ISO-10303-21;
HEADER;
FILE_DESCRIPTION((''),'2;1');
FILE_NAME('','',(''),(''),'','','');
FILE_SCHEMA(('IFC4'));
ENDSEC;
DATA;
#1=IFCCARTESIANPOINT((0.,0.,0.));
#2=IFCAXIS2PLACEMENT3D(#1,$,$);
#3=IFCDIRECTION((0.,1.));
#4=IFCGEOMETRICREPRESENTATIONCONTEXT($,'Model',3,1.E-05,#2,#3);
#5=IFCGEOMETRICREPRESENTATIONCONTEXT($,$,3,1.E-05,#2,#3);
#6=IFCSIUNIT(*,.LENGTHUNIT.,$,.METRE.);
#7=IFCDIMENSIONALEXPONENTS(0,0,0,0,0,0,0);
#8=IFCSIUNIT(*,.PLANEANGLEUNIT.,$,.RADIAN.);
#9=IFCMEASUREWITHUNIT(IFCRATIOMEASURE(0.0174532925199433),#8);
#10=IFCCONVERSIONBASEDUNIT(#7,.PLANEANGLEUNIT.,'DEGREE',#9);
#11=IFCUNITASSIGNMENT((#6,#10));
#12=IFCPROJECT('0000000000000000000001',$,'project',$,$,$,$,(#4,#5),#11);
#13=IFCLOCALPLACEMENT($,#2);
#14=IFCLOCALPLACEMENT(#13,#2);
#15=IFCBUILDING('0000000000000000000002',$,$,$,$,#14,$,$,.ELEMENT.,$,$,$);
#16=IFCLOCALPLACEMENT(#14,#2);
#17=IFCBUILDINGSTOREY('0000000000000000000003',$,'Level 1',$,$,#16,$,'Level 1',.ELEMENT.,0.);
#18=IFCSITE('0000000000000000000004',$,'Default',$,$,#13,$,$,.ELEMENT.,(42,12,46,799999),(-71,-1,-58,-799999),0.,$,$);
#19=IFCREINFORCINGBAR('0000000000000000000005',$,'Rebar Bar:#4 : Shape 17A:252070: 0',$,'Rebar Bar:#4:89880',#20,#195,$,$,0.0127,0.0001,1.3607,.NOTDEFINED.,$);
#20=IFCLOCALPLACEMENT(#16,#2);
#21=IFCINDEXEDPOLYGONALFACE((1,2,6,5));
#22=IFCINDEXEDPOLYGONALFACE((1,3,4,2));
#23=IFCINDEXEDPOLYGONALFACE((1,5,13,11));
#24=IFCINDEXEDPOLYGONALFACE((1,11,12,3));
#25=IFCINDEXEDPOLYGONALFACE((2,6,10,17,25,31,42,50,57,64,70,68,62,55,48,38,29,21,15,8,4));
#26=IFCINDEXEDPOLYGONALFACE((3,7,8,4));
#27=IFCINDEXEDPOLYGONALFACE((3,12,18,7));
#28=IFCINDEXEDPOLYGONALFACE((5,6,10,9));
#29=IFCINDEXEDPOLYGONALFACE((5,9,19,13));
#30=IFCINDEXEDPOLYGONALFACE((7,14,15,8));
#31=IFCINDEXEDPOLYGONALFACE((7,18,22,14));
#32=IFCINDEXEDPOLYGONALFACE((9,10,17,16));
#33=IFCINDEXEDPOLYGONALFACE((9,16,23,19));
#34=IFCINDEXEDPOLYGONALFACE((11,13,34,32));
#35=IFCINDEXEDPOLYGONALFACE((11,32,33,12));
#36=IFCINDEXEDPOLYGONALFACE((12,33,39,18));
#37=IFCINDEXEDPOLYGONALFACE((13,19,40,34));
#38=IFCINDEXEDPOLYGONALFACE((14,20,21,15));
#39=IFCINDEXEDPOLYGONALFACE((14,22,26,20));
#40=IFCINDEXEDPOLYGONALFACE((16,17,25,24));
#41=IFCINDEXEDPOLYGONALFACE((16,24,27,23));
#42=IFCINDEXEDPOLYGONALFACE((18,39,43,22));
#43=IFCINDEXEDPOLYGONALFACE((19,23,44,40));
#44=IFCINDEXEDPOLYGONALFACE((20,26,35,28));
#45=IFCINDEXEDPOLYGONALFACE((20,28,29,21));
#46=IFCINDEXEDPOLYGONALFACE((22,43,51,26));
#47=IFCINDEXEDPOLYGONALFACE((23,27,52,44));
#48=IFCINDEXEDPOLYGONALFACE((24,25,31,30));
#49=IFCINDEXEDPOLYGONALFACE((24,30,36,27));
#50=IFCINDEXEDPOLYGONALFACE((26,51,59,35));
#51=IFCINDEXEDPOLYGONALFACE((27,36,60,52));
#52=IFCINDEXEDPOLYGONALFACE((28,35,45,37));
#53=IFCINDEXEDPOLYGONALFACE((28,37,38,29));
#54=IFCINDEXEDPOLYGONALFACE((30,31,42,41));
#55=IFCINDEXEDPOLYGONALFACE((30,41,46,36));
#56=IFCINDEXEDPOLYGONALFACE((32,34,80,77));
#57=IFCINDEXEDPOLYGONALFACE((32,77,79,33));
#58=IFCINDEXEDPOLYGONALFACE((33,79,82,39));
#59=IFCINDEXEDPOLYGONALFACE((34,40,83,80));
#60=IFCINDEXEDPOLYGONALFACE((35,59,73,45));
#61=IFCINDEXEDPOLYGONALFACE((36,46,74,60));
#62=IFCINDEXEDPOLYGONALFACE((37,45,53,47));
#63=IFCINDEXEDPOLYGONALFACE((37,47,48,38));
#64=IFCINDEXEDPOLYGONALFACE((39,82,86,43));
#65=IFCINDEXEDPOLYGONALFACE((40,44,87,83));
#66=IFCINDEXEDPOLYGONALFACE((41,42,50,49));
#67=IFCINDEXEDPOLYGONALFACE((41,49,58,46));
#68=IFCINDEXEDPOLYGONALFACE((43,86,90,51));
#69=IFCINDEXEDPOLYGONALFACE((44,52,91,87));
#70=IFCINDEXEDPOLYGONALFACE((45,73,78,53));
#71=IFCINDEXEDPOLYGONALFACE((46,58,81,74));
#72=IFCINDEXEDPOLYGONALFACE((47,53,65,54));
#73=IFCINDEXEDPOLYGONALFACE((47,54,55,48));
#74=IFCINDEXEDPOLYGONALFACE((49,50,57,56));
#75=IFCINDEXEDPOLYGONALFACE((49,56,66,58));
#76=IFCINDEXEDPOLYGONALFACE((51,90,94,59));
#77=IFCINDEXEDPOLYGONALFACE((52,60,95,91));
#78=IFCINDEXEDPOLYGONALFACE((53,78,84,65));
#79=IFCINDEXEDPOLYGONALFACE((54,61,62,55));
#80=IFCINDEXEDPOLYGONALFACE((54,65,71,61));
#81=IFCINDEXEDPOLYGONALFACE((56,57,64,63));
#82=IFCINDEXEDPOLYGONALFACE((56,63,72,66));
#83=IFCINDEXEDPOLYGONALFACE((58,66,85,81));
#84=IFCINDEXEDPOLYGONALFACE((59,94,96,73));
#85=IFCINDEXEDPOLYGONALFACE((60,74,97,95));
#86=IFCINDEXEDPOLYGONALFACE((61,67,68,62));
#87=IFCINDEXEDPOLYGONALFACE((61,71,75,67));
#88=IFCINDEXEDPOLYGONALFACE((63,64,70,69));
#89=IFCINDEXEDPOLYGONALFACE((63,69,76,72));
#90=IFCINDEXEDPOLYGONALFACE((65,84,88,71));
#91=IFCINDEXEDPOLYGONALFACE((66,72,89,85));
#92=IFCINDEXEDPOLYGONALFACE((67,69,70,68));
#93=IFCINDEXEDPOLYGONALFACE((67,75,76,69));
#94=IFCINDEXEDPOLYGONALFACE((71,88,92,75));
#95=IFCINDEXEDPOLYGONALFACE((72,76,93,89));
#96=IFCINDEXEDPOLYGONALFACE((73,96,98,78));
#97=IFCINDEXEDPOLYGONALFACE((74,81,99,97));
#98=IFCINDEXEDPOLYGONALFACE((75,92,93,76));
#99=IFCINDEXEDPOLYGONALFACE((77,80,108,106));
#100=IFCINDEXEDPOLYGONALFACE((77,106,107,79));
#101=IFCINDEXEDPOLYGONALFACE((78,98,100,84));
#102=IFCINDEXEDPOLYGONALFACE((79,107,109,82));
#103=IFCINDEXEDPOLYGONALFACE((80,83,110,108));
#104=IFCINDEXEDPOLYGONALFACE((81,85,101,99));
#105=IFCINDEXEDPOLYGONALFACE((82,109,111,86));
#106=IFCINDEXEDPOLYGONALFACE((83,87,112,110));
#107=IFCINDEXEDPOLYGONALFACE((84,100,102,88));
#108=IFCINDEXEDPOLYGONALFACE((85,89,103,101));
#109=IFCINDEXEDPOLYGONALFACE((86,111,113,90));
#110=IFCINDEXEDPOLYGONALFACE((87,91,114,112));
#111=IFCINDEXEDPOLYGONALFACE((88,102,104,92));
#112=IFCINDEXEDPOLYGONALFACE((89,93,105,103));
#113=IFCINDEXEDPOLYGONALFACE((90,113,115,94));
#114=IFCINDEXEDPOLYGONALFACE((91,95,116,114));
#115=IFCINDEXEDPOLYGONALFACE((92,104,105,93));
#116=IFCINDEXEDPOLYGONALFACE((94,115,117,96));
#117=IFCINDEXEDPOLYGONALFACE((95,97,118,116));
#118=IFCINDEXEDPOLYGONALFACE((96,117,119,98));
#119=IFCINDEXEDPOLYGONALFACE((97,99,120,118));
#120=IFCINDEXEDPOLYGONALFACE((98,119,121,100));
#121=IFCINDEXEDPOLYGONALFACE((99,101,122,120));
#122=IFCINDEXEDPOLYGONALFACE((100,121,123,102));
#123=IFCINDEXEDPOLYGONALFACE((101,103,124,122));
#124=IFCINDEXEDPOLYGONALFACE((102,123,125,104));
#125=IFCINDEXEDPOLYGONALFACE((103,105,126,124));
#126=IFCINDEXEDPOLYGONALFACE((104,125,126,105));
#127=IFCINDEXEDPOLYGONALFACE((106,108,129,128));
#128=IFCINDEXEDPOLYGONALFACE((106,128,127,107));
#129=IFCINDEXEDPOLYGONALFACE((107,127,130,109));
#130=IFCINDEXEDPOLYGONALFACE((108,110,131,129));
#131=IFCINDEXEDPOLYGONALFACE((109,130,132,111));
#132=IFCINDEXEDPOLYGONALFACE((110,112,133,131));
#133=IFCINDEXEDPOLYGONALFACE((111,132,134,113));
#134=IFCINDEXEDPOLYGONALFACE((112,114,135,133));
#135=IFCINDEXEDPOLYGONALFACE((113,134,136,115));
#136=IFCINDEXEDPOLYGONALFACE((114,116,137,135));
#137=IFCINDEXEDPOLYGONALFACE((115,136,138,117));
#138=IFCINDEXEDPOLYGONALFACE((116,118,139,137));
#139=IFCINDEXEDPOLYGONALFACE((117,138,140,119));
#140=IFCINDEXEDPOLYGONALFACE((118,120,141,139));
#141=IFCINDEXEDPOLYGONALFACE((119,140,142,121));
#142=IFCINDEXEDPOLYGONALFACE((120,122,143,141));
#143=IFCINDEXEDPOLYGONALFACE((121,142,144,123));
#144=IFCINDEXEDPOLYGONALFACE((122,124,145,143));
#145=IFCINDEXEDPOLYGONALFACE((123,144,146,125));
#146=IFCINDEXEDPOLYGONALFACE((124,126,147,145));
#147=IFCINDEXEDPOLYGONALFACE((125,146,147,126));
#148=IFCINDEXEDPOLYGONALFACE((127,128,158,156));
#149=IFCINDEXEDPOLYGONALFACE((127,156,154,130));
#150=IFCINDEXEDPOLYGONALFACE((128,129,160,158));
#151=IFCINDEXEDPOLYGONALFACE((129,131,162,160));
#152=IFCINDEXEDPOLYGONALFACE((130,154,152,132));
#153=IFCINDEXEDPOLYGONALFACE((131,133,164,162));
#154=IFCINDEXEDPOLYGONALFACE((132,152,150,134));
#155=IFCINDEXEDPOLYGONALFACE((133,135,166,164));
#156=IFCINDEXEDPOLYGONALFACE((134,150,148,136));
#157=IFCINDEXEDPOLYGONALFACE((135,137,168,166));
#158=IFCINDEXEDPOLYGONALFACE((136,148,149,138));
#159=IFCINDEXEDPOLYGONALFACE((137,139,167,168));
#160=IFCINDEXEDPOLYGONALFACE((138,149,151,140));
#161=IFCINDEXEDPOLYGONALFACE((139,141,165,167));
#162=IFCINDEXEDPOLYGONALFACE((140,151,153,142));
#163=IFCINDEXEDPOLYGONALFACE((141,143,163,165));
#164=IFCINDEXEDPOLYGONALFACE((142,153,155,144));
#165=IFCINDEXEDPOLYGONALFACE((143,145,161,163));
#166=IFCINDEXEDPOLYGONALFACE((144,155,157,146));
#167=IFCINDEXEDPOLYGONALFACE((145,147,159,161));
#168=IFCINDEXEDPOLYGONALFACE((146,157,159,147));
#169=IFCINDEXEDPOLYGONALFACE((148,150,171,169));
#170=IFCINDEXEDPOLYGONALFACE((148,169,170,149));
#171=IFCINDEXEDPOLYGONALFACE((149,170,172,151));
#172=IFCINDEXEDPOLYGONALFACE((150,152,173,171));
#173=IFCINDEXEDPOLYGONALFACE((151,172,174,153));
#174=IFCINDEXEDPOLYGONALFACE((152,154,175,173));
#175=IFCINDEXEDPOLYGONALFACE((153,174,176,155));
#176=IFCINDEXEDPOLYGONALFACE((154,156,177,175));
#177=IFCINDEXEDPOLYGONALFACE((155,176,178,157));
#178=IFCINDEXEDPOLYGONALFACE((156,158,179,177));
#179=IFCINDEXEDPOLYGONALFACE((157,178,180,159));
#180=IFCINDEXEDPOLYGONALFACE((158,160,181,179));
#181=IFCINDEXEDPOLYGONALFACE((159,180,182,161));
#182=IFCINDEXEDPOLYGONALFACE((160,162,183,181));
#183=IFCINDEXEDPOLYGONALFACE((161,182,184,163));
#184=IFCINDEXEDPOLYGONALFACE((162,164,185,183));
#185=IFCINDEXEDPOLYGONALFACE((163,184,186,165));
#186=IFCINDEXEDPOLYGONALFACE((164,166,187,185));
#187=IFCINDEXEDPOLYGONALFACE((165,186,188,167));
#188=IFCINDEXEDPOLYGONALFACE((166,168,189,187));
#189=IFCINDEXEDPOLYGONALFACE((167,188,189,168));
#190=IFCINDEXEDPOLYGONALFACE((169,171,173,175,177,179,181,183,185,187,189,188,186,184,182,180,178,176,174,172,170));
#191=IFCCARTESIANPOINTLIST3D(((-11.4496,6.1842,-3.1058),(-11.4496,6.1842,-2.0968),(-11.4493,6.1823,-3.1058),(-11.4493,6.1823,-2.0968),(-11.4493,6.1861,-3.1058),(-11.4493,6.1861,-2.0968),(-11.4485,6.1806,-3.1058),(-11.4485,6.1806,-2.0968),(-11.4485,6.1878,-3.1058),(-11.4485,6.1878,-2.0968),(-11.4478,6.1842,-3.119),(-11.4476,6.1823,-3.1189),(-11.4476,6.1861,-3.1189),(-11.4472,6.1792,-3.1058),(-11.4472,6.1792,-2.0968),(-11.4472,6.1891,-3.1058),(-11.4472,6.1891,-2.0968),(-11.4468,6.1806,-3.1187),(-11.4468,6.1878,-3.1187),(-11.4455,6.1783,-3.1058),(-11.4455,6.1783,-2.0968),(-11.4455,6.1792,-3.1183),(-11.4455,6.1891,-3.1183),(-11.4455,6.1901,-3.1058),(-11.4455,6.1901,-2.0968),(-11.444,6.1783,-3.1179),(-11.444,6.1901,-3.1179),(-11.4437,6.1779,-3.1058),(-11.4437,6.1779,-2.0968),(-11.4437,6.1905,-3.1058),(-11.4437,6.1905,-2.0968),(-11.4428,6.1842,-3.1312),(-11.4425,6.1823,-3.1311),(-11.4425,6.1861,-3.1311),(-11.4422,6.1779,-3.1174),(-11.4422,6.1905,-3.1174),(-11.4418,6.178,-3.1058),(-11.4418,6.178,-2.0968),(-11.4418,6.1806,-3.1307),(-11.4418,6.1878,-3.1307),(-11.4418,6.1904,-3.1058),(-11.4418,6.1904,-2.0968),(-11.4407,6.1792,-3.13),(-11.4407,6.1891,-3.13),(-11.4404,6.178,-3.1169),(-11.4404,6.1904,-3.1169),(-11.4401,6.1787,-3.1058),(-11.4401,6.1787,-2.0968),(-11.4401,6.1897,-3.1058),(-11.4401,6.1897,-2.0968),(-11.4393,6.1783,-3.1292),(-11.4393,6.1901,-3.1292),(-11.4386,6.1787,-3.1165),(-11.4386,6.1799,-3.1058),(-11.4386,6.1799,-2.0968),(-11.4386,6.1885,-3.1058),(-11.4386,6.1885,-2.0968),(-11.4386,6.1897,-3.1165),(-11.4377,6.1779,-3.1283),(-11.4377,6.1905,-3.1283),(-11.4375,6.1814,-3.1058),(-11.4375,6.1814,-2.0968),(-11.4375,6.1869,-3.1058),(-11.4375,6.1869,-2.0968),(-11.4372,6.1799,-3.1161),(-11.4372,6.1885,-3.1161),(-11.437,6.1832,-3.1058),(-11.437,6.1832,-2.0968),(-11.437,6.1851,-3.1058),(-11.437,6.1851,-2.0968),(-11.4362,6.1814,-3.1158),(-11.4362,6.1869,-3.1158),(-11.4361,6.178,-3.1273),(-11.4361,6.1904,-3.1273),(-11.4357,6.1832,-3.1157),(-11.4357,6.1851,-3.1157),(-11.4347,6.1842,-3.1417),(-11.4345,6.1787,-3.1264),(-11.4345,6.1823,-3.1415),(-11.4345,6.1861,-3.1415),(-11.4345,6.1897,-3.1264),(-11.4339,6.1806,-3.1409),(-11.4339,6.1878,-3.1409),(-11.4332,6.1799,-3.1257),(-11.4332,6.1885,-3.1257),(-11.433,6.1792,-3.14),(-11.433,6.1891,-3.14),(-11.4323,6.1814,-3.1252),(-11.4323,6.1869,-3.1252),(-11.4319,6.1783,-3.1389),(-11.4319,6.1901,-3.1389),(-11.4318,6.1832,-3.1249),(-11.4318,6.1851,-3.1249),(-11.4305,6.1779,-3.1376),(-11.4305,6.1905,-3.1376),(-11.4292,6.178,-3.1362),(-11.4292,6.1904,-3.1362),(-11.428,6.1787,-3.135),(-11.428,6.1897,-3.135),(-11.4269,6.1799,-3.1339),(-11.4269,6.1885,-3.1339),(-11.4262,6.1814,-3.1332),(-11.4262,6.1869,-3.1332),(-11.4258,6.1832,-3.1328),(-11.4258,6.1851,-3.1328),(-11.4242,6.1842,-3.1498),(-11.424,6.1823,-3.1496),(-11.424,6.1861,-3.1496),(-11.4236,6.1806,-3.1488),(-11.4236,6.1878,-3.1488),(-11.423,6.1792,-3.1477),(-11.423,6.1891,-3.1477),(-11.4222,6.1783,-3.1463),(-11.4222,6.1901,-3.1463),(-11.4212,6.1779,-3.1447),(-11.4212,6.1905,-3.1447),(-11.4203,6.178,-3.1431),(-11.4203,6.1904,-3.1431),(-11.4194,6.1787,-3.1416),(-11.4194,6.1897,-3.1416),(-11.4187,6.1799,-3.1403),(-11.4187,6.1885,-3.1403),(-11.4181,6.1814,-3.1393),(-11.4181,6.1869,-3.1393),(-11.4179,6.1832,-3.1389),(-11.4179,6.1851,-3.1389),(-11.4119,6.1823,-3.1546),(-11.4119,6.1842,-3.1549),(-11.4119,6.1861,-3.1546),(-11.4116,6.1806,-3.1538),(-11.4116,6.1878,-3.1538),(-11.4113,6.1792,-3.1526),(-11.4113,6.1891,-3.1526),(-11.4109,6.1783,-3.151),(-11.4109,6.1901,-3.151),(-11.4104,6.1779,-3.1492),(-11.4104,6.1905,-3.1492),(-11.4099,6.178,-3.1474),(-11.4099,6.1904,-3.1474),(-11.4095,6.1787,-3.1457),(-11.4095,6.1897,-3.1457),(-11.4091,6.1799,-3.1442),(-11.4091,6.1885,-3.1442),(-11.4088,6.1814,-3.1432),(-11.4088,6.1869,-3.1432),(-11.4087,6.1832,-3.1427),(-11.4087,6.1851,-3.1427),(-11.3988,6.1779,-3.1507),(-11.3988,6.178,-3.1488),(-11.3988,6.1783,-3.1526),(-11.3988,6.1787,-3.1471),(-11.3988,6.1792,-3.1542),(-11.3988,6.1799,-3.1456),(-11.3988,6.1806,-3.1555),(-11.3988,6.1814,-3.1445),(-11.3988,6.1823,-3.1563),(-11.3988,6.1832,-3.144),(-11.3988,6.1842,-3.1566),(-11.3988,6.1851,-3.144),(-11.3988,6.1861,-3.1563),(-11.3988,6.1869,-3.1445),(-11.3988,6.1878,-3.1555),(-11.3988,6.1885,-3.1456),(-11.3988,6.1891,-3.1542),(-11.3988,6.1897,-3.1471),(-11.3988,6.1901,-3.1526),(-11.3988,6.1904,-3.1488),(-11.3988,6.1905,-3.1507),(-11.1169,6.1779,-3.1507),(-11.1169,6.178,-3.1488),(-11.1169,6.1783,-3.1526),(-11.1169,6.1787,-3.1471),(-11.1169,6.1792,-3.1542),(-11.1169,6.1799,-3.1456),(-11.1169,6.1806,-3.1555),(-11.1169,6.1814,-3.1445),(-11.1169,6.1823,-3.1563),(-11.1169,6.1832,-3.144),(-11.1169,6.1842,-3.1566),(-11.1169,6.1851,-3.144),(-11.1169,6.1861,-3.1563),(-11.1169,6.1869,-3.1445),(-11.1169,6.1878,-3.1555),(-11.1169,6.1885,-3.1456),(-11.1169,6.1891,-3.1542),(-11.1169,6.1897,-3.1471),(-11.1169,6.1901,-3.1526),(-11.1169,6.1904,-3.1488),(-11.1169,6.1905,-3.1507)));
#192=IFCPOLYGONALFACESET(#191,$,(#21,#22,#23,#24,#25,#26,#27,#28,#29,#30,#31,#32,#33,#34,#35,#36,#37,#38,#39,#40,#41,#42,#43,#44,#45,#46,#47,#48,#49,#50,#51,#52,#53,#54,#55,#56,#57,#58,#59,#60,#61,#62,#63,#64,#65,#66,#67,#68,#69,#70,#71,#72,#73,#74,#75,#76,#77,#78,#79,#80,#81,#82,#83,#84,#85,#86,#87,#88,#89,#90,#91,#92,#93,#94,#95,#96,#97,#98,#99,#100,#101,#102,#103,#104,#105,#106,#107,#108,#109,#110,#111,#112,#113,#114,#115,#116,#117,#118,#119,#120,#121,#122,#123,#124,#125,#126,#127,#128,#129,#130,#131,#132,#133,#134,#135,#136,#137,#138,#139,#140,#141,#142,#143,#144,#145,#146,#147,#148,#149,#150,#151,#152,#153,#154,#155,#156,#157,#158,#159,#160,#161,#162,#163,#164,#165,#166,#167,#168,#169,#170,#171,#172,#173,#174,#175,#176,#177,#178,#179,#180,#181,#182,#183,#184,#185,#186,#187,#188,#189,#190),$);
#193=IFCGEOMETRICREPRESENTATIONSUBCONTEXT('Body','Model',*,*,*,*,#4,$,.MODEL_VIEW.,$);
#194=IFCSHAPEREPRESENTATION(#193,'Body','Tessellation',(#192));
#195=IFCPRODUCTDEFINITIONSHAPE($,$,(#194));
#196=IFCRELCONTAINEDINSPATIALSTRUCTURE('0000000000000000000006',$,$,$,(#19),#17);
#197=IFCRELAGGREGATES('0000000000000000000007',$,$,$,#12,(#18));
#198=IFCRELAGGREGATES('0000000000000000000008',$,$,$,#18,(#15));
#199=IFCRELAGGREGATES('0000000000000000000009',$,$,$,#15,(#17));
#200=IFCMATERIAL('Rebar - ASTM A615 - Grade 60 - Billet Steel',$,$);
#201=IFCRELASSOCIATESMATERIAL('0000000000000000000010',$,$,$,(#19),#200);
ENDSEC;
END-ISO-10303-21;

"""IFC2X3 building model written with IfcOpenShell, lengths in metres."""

from ifc_helpers import new_model, entity, si_unit, converted_unit, direction, origin, place, context, subcontext, project, spatial, material, element, save


model = new_model("IFC2X3")

# Units and contexts
model_context = context("Model", 3, precision=1e-05, world=origin(), true_north=direction((0.0, 1.0)))
context_of_model = context(None, 3, precision=1e-05, world=origin(), true_north=direction((0.0, 1.0)))
body_context = subcontext(model_context, "Body", "Model", "MODEL_VIEW")
ifc_project = project(units=[si_unit("LENGTHUNIT", "METRE"), converted_unit("PLANEANGLEUNIT", "DEGREE", entity("IfcRatioMeasure", 0.0174532925199433), si_unit("PLANEANGLEUNIT", "RADIAN"), dimensions=[0, 0, 0, 0, 0, 0, 0])], contexts=[model_context, context_of_model])

# Site, building, storey
site_placement = place(None, origin())
site = spatial("IfcSite", under=ifc_project, at=site_placement, Name="Default", CompositionType="ELEMENT", RefLatitude=(42, 12, 46, 799999), RefLongitude=(-71, -1, -58, -799999), RefElevation=0.0)
building_placement = place(site_placement, origin())
building = spatial("IfcBuilding", under=site, at=building_placement, CompositionType="ELEMENT")
storey_placement = place(building_placement, origin())
storey = spatial("IfcBuildingStorey", under=building, at=storey_placement, Name="Level 1", LongName="Level 1", CompositionType="ELEMENT", Elevation=0.0)

# Reinforcing bar
ifc_material_1 = material(Name="Rebar - ASTM A615 - Grade 60 - Billet Steel")
reinforcing_bar_1_placement = place(storey_placement, origin())
element("IfcReinforcingBar", 1, at=reinforcing_bar_1_placement, inside=storey, material=ifc_material_1, Name="Rebar Bar:#4 : Shape 17A:252070: 0", ObjectType="Rebar Bar:#4:89880", BarLength=1.3607, BarRole="NOTDEFINED", CrossSectionArea=0.0001, NominalDiameter=0.0127, context=body_context, shape_type="AdvancedSweptSolid", body=[
    entity("IfcSweptDiskSolid", entity("IfcCompositeCurve", [entity("IfcCompositeCurveSegment", "CONTINUOUS", True, entity("IfcPolyline", [entity("IfcCartesianPoint", [-11.4432, 6.1842, -2.0968]), entity("IfcCartesianPoint", [-11.4432, 6.1842, -3.1058])])), entity("IfcCompositeCurveSegment", "CONTINUOUS", True, entity("IfcTrimmedCurve", entity("IfcCircle", entity("IfcAxis2Placement3D", entity("IfcCartesianPoint", [-11.3988, 6.1842, -3.1058]), entity("IfcDirection", [0.0, -1.0, 0.0]), entity("IfcDirection", [0.0, 0.0, -1.0])), 0.0445), [entity("IfcParameterValue", 270.0)], [entity("IfcParameterValue", 360.0)], True, "PARAMETER")), entity("IfcCompositeCurveSegment", "CONTINUOUS", True, entity("IfcPolyline", [entity("IfcCartesianPoint", [-11.3988, 6.1842, -3.1503]), entity("IfcCartesianPoint", [-11.1169, 6.1842, -3.1503])]))], False), 0.0063, None, 0.0, 92.0),
])

save(model, "model.ifc")
